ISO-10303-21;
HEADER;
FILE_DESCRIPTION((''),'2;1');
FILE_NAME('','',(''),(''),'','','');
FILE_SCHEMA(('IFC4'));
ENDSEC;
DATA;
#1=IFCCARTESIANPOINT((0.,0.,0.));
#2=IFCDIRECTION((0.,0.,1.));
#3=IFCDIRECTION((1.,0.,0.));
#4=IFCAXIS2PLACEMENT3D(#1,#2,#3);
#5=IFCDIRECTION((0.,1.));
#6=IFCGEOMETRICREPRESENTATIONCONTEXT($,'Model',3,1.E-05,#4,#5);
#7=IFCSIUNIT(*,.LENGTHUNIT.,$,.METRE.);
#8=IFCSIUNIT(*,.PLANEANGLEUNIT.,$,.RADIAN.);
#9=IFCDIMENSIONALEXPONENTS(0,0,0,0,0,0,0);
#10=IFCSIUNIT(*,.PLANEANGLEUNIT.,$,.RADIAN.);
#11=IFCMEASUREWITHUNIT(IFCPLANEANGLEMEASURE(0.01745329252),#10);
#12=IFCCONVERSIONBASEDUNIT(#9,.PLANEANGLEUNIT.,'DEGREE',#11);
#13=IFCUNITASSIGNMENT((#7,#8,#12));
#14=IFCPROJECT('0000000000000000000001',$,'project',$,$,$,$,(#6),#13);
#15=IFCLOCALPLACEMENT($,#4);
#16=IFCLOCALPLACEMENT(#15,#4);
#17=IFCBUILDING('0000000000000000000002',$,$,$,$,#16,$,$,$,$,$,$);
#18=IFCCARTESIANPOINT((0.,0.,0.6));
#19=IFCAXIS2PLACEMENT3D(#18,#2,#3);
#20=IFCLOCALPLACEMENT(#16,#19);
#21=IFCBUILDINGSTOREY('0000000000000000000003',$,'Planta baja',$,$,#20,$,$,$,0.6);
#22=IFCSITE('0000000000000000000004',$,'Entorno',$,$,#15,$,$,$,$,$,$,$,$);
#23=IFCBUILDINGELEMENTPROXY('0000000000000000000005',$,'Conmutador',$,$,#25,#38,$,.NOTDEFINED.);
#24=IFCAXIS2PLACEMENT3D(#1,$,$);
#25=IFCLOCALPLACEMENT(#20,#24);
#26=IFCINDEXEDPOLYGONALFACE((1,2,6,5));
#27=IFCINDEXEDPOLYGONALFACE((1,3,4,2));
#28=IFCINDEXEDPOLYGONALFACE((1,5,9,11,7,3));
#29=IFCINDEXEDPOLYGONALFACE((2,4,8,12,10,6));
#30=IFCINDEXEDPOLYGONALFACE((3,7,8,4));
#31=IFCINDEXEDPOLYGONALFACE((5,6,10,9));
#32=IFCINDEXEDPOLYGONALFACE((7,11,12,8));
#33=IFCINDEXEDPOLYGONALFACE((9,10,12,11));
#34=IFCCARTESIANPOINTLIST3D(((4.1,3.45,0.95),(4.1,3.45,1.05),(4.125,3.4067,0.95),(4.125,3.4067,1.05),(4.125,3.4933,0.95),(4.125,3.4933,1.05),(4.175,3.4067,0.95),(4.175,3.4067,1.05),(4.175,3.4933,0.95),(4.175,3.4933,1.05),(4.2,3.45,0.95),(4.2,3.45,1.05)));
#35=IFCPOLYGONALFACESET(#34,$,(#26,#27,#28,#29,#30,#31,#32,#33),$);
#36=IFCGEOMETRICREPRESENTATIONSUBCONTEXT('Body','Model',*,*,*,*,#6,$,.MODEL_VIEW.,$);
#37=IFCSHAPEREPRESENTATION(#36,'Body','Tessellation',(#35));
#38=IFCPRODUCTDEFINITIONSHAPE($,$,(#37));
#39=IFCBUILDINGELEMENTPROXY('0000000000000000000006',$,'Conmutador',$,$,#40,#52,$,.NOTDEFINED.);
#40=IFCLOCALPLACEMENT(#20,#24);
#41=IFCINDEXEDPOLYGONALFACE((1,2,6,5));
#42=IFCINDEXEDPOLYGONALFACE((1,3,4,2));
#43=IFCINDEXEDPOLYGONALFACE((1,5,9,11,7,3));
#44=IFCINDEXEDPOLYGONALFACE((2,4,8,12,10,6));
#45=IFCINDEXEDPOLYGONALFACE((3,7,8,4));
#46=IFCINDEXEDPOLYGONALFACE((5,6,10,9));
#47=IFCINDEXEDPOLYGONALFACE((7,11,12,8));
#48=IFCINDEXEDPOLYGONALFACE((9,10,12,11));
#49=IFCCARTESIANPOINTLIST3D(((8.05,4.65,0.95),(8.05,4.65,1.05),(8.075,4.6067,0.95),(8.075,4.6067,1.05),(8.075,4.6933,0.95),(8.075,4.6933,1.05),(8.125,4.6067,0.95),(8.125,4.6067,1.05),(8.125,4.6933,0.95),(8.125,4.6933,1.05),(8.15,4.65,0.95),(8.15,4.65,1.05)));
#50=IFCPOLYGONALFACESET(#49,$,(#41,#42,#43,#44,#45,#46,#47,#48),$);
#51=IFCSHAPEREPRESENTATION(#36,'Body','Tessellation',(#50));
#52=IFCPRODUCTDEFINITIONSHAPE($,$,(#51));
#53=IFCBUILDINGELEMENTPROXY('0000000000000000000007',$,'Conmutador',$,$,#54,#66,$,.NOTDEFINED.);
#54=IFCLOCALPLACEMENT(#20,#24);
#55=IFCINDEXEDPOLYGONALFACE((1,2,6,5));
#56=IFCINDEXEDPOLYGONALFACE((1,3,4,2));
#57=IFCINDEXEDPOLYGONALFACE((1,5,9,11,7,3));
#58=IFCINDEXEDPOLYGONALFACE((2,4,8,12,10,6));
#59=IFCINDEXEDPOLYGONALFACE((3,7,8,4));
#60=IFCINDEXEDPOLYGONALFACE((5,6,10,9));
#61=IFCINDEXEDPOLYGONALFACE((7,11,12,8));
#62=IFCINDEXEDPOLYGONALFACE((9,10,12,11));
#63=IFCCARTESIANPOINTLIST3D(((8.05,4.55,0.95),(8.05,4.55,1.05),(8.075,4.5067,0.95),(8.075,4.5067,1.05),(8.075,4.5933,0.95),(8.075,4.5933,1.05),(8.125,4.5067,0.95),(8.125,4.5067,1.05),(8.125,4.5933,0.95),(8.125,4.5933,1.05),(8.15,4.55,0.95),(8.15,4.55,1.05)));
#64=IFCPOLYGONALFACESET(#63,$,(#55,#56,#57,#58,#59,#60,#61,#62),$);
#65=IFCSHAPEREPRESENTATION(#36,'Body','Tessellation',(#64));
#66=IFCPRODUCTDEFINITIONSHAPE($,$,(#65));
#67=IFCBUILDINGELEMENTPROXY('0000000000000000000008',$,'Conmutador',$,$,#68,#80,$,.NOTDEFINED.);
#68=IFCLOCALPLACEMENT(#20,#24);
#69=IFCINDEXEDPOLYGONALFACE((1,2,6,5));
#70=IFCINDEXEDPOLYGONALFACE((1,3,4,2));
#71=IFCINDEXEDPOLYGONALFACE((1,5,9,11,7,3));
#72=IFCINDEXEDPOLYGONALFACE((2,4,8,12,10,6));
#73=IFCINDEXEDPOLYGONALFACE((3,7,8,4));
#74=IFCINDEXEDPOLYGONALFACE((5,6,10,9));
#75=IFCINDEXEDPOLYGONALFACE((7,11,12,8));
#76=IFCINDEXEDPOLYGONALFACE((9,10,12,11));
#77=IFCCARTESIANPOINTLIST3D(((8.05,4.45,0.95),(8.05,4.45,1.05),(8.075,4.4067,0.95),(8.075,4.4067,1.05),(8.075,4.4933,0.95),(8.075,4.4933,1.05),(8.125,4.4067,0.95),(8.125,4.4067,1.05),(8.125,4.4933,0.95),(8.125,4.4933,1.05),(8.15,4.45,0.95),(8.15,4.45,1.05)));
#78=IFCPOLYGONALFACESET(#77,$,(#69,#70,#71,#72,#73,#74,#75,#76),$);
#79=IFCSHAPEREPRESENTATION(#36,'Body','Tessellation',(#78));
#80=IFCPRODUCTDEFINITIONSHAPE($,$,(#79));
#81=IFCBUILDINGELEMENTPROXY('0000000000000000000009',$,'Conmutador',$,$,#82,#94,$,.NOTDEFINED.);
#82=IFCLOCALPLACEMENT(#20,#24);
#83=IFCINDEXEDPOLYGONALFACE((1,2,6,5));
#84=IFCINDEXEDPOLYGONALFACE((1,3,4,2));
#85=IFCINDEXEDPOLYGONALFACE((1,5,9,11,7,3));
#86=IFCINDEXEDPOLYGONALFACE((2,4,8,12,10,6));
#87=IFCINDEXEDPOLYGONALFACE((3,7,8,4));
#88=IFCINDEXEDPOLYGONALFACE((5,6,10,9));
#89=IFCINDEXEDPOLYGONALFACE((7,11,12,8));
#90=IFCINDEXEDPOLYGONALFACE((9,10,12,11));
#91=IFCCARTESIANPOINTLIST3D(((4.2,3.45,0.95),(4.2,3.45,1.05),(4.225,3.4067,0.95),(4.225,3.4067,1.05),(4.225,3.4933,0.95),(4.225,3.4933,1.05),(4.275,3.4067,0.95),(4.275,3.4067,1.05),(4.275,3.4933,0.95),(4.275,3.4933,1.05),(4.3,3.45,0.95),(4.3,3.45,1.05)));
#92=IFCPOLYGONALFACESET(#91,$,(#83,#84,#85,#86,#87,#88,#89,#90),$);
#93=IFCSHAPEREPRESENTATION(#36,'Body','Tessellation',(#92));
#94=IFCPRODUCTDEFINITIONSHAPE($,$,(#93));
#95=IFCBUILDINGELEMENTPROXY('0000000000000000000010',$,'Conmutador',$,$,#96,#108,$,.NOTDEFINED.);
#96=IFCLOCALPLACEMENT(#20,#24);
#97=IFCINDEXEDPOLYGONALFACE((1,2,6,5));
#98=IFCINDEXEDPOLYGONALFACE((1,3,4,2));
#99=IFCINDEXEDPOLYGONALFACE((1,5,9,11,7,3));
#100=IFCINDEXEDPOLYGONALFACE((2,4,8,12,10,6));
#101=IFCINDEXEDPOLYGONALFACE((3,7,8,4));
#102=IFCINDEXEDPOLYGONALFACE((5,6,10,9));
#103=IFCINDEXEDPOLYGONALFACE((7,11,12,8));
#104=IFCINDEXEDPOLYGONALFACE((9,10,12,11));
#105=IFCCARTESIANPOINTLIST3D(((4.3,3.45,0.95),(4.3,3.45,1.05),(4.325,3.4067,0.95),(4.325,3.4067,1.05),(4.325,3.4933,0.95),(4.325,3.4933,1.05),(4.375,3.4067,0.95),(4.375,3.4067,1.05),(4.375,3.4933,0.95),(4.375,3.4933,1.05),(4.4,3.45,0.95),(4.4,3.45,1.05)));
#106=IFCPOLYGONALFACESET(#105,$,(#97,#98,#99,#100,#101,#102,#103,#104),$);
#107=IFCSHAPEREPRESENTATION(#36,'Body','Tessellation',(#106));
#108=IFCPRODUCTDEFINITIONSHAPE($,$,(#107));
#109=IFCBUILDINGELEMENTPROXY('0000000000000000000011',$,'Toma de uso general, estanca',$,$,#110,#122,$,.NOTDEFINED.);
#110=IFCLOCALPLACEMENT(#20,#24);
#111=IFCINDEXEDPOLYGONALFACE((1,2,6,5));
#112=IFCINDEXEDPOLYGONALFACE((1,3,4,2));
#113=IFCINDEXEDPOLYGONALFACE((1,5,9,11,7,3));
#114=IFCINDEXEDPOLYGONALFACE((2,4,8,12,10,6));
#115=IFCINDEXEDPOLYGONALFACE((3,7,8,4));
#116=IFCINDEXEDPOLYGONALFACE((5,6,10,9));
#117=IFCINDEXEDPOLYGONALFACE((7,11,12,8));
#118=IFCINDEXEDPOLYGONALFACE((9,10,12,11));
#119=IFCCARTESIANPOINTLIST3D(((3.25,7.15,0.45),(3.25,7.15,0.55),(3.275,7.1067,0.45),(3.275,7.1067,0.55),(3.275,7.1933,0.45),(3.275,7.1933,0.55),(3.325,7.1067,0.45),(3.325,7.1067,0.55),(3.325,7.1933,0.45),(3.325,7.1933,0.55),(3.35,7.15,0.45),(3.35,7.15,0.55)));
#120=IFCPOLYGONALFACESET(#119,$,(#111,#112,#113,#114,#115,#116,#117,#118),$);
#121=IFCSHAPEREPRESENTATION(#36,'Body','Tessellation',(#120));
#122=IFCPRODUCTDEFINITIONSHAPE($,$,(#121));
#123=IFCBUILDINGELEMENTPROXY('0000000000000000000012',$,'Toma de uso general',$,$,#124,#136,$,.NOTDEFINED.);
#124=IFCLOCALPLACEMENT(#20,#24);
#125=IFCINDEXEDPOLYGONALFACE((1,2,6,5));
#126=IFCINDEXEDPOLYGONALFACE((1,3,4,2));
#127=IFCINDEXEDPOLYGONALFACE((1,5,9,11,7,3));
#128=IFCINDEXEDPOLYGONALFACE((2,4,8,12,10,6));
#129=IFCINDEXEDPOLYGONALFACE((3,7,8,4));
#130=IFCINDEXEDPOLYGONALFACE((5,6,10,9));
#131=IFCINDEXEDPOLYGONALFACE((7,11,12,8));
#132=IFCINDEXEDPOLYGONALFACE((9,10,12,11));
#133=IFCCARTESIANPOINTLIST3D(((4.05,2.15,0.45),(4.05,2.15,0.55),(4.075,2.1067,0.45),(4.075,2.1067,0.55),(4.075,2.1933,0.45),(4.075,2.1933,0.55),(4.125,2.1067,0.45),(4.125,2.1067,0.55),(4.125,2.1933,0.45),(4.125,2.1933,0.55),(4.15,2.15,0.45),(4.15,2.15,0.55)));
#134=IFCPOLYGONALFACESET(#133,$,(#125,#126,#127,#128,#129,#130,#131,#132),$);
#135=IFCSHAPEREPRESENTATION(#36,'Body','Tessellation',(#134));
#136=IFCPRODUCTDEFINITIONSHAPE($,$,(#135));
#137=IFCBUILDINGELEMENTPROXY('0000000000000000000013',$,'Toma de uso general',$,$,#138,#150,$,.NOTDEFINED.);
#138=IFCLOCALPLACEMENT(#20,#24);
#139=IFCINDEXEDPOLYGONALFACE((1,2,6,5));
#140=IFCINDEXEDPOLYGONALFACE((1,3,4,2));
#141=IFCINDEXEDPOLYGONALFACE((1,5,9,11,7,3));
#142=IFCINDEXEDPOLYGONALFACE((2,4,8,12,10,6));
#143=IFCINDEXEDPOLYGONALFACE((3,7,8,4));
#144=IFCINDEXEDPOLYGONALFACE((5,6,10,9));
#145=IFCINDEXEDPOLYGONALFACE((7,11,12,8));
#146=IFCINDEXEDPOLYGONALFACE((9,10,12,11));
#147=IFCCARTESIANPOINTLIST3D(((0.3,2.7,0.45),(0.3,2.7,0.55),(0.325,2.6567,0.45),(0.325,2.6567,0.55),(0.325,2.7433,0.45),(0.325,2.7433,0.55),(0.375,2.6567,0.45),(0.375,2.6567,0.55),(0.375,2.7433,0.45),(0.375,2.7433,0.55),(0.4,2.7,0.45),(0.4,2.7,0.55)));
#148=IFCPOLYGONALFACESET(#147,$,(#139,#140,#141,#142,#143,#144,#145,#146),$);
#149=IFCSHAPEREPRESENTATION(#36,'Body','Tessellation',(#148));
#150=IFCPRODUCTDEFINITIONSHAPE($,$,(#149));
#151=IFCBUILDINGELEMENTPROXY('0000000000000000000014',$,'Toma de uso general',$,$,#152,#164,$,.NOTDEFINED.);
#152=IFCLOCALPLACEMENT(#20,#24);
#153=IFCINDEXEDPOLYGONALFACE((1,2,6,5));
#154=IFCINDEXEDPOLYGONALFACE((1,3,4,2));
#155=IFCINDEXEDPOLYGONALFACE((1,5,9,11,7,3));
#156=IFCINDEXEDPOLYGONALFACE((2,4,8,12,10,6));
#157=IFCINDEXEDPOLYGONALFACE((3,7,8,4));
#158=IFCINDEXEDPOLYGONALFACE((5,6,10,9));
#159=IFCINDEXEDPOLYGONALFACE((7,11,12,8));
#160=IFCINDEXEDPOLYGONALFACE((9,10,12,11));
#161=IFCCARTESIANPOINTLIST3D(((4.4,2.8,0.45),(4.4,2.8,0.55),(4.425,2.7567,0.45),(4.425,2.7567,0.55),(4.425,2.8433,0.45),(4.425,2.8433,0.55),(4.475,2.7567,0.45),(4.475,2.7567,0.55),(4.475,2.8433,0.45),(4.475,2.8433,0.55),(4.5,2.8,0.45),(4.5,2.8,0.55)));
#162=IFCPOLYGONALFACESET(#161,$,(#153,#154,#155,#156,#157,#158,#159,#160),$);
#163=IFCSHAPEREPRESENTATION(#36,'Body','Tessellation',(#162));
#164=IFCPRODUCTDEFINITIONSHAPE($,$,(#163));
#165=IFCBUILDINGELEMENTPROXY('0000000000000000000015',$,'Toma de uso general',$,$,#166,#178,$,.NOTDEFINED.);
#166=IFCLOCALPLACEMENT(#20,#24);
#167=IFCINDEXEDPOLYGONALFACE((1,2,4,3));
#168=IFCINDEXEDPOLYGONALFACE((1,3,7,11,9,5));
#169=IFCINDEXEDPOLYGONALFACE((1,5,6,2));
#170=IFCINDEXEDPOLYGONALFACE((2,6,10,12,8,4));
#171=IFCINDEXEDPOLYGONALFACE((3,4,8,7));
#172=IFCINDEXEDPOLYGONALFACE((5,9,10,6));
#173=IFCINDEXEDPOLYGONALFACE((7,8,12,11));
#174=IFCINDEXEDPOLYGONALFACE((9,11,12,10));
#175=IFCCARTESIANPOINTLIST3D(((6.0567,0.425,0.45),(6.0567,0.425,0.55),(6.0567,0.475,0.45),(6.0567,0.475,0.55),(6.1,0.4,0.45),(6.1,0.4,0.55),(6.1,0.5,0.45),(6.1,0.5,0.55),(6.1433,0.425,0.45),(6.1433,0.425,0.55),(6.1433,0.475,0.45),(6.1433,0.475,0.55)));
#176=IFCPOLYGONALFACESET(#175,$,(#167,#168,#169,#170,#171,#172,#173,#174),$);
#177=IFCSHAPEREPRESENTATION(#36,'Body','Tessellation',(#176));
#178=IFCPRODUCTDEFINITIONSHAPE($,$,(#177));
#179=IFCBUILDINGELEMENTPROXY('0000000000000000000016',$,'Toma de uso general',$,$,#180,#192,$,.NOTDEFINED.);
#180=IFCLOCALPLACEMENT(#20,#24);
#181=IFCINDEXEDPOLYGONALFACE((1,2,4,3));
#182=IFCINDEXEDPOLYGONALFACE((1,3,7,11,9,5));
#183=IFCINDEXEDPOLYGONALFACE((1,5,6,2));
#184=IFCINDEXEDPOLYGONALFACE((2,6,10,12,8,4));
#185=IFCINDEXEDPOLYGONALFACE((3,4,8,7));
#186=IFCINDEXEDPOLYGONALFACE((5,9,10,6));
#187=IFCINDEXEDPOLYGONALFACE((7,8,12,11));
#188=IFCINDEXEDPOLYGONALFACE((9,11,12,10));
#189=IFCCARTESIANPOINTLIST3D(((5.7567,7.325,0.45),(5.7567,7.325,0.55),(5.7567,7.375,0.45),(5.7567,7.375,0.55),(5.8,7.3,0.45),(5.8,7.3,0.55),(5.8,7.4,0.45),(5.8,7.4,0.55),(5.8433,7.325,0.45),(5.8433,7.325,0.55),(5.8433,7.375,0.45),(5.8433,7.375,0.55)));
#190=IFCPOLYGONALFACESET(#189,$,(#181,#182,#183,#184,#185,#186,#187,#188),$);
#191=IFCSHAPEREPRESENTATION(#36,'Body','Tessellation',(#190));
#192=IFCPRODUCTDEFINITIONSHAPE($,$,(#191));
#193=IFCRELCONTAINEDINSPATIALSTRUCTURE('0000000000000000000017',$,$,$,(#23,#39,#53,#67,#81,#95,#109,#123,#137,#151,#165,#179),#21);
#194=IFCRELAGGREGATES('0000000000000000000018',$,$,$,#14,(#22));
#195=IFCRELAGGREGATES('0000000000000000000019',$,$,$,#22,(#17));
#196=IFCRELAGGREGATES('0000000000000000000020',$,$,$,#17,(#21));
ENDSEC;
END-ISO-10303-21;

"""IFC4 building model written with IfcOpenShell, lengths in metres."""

from ifc_helpers import new_model, entity, si_unit, converted_unit, direction, frame, origin_with_axes, place, context, subcontext, project, spatial, polyline, outline, extrude, source, transform, mapped, element, save


model = new_model("IFC4")

# Units and contexts
model_context = context("Model", 3, precision=1e-05, world=origin_with_axes(), true_north=direction((0.0, 1.0)))
body_context = subcontext(model_context, "Body", "Model", "MODEL_VIEW")
ifc_project = project(units=[si_unit("LENGTHUNIT", "METRE"), si_unit("PLANEANGLEUNIT", "RADIAN"), converted_unit("PLANEANGLEUNIT", "DEGREE", entity("IfcPlaneAngleMeasure", 0.01745329252), si_unit("PLANEANGLEUNIT", "RADIAN"), dimensions=[0, 0, 0, 0, 0, 0, 0])], contexts=[model_context])

# Site, building, storey
site_placement = place(None, origin_with_axes())
site = spatial("IfcSite", under=ifc_project, at=site_placement, Name="Entorno")
building_placement = place(site_placement, origin_with_axes())
building = spatial("IfcBuilding", under=site, at=building_placement)
storey_placement = place(building_placement, frame((0.0, 0.0, 0.6), z_axis=(0.0, 0.0, 1.0), x_axis=(1.0, 0.0, 0.0)))
storey = spatial("IfcBuildingStorey", under=building, at=storey_placement, Name="Planta baja", Elevation=0.6)

# Building element proxies
shared_shape_1 = source(origin_with_axes(), body_context, "Body", "SolidModel", [
    extrude(outline(polyline([(0.05, 0.0), (0.025, 0.0433), (-0.025, 0.0433), (-0.05, 0.0), (-0.025, -0.0433), (0.025, -0.0433), (0.05, 0.0)])), frame((0.0, 0.0, -0.05), z_axis=(0.0, 0.0, 1.0), x_axis=(1.0, 0.0, 0.0)), (0.0, 0.0, 1.0), 0.1),
])
proxy_1_placement = place(storey_placement, frame((0.0, 0.0, -0.6), z_axis=(0.0, 0.0, 1.0), x_axis=(1.0, 0.0, 0.0)))
element("IfcBuildingElementProxy", 1, at=proxy_1_placement, inside=storey, Name="Conmutador", PredefinedType="NOTDEFINED", context=body_context, shape_type="Brep", body=[
    mapped(shared_shape_1, transform((4.15, 3.45, 1.6), x_axis=(1.0, 0.0, 0.0), y_axis=(0.0, 1.0, 0.0), z_axis=(0.0, 0.0, 1.0))),
])
proxy_2_placement = place(storey_placement, frame((0.0, 0.0, -0.6), z_axis=(0.0, 0.0, 1.0), x_axis=(1.0, 0.0, 0.0)))
element("IfcBuildingElementProxy", 2, at=proxy_2_placement, inside=storey, Name="Conmutador", PredefinedType="NOTDEFINED", context=body_context, shape_type="Brep", body=[
    mapped(shared_shape_1, transform((8.1, 4.65, 1.6), x_axis=(1.0, 0.0, 0.0), y_axis=(0.0, 1.0, 0.0), z_axis=(0.0, 0.0, 1.0))),
])
proxy_3_placement = place(storey_placement, frame((0.0, 0.0, -0.6), z_axis=(0.0, 0.0, 1.0), x_axis=(1.0, 0.0, 0.0)))
element("IfcBuildingElementProxy", 3, at=proxy_3_placement, inside=storey, Name="Conmutador", PredefinedType="NOTDEFINED", context=body_context, shape_type="Brep", body=[
    mapped(shared_shape_1, transform((8.1, 4.55, 1.6), x_axis=(1.0, 0.0, 0.0), y_axis=(0.0, 1.0, 0.0), z_axis=(0.0, 0.0, 1.0))),
])
proxy_4_placement = place(storey_placement, frame((0.0, 0.0, -0.6), z_axis=(0.0, 0.0, 1.0), x_axis=(1.0, 0.0, 0.0)))
element("IfcBuildingElementProxy", 4, at=proxy_4_placement, inside=storey, Name="Conmutador", PredefinedType="NOTDEFINED", context=body_context, shape_type="Brep", body=[
    mapped(shared_shape_1, transform((8.1, 4.45, 1.6), x_axis=(1.0, 0.0, 0.0), y_axis=(0.0, 1.0, 0.0), z_axis=(0.0, 0.0, 1.0))),
])
proxy_5_placement = place(storey_placement, frame((0.0, 0.0, -0.6), z_axis=(0.0, 0.0, 1.0), x_axis=(1.0, 0.0, 0.0)))
element("IfcBuildingElementProxy", 5, at=proxy_5_placement, inside=storey, Name="Conmutador", PredefinedType="NOTDEFINED", context=body_context, shape_type="Brep", body=[
    mapped(shared_shape_1, transform((4.25, 3.45, 1.6), x_axis=(1.0, 0.0, 0.0), y_axis=(0.0, 1.0, 0.0), z_axis=(0.0, 0.0, 1.0))),
])
proxy_6_placement = place(storey_placement, frame((0.0, 0.0, -0.6), z_axis=(0.0, 0.0, 1.0), x_axis=(1.0, 0.0, 0.0)))
element("IfcBuildingElementProxy", 6, at=proxy_6_placement, inside=storey, Name="Conmutador", PredefinedType="NOTDEFINED", context=body_context, shape_type="Brep", body=[
    mapped(shared_shape_1, transform((4.35, 3.45, 1.6), x_axis=(1.0, 0.0, 0.0), y_axis=(0.0, 1.0, 0.0), z_axis=(0.0, 0.0, 1.0))),
])
shared_shape_2 = source(origin_with_axes(), body_context, "Body", "SolidModel", [
    extrude(outline(polyline([(0.05, 0.0), (0.025, 0.0433), (-0.025, 0.0433), (-0.05, 0.0), (-0.025, -0.0433), (0.025, -0.0433), (0.05, 0.0)])), frame((0.0, 0.0, -0.05), z_axis=(0.0, 0.0, 1.0), x_axis=(1.0, 0.0, 0.0)), (0.0, 0.0, 1.0), 0.1),
])
proxy_7_placement = place(storey_placement, frame((0.0, 0.0, -0.6), z_axis=(0.0, 0.0, 1.0), x_axis=(1.0, 0.0, 0.0)))
element("IfcBuildingElementProxy", 7, at=proxy_7_placement, inside=storey, Name="Toma de uso general, estanca", PredefinedType="NOTDEFINED", context=body_context, shape_type="Brep", body=[
    mapped(shared_shape_2, transform((3.3, 7.15, 1.1), x_axis=(-1.0, 0.0, 0.0), y_axis=(0.0, -1.0, 0.0), z_axis=(0.0, 0.0, 1.0))),
])
shared_shape_3 = source(origin_with_axes(), body_context, "Body", "SolidModel", [
    extrude(outline(polyline([(0.05, 0.0), (0.025, 0.0433), (-0.025, 0.0433), (-0.05, 0.0), (-0.025, -0.0433), (0.025, -0.0433), (0.05, 0.0)])), frame((0.0, 0.0, -0.05), z_axis=(0.0, 0.0, 1.0), x_axis=(1.0, 0.0, 0.0)), (0.0, 0.0, 1.0), 0.1),
])
proxy_8_placement = place(storey_placement, frame((0.0, 0.0, -0.6), z_axis=(0.0, 0.0, 1.0), x_axis=(1.0, 0.0, 0.0)))
element("IfcBuildingElementProxy", 8, at=proxy_8_placement, inside=storey, Name="Toma de uso general", PredefinedType="NOTDEFINED", context=body_context, shape_type="Brep", body=[
    mapped(shared_shape_3, transform((4.1, 2.15, 1.1), x_axis=(-1.0, 0.0, 0.0), y_axis=(0.0, -1.0, 0.0), z_axis=(0.0, 0.0, 1.0))),
])
proxy_9_placement = place(storey_placement, frame((0.0, 0.0, -0.6), z_axis=(0.0, 0.0, 1.0), x_axis=(1.0, 0.0, 0.0)))
element("IfcBuildingElementProxy", 9, at=proxy_9_placement, inside=storey, Name="Toma de uso general", PredefinedType="NOTDEFINED", context=body_context, shape_type="Brep", body=[
    mapped(shared_shape_3, transform((0.35, 2.7, 1.1), x_axis=(1.0, 0.0, 0.0), y_axis=(0.0, 1.0, 0.0), z_axis=(0.0, 0.0, 1.0))),
])
proxy_10_placement = place(storey_placement, frame((0.0, 0.0, -0.6), z_axis=(0.0, 0.0, 1.0), x_axis=(1.0, 0.0, 0.0)))
element("IfcBuildingElementProxy", 10, at=proxy_10_placement, inside=storey, Name="Toma de uso general", PredefinedType="NOTDEFINED", context=body_context, shape_type="Brep", body=[
    mapped(shared_shape_3, transform((4.45, 2.8, 1.1), x_axis=(1.0, 0.0, 0.0), y_axis=(0.0, 1.0, 0.0), z_axis=(0.0, 0.0, 1.0))),
])
proxy_11_placement = place(storey_placement, frame((0.0, 0.0, -0.6), z_axis=(0.0, 0.0, 1.0), x_axis=(1.0, 0.0, 0.0)))
element("IfcBuildingElementProxy", 11, at=proxy_11_placement, inside=storey, Name="Toma de uso general", PredefinedType="NOTDEFINED", context=body_context, shape_type="Brep", body=[
    mapped(shared_shape_3, transform((6.1, 0.45, 1.1), x_axis=(0.0, 1.0, 0.0), y_axis=(-1.0, 0.0, 0.0), z_axis=(0.0, 0.0, 1.0))),
])
proxy_12_placement = place(storey_placement, frame((0.0, 0.0, -0.6), z_axis=(0.0, 0.0, 1.0), x_axis=(1.0, 0.0, 0.0)))
element("IfcBuildingElementProxy", 12, at=proxy_12_placement, inside=storey, Name="Toma de uso general", PredefinedType="NOTDEFINED", context=body_context, shape_type="Brep", body=[
    mapped(shared_shape_3, transform((5.8, 7.35, 1.1), x_axis=(0.0, -1.0, 0.0), y_axis=(1.0, 0.0, 0.0), z_axis=(0.0, 0.0, 1.0))),
])

save(model, "model.ifc")
